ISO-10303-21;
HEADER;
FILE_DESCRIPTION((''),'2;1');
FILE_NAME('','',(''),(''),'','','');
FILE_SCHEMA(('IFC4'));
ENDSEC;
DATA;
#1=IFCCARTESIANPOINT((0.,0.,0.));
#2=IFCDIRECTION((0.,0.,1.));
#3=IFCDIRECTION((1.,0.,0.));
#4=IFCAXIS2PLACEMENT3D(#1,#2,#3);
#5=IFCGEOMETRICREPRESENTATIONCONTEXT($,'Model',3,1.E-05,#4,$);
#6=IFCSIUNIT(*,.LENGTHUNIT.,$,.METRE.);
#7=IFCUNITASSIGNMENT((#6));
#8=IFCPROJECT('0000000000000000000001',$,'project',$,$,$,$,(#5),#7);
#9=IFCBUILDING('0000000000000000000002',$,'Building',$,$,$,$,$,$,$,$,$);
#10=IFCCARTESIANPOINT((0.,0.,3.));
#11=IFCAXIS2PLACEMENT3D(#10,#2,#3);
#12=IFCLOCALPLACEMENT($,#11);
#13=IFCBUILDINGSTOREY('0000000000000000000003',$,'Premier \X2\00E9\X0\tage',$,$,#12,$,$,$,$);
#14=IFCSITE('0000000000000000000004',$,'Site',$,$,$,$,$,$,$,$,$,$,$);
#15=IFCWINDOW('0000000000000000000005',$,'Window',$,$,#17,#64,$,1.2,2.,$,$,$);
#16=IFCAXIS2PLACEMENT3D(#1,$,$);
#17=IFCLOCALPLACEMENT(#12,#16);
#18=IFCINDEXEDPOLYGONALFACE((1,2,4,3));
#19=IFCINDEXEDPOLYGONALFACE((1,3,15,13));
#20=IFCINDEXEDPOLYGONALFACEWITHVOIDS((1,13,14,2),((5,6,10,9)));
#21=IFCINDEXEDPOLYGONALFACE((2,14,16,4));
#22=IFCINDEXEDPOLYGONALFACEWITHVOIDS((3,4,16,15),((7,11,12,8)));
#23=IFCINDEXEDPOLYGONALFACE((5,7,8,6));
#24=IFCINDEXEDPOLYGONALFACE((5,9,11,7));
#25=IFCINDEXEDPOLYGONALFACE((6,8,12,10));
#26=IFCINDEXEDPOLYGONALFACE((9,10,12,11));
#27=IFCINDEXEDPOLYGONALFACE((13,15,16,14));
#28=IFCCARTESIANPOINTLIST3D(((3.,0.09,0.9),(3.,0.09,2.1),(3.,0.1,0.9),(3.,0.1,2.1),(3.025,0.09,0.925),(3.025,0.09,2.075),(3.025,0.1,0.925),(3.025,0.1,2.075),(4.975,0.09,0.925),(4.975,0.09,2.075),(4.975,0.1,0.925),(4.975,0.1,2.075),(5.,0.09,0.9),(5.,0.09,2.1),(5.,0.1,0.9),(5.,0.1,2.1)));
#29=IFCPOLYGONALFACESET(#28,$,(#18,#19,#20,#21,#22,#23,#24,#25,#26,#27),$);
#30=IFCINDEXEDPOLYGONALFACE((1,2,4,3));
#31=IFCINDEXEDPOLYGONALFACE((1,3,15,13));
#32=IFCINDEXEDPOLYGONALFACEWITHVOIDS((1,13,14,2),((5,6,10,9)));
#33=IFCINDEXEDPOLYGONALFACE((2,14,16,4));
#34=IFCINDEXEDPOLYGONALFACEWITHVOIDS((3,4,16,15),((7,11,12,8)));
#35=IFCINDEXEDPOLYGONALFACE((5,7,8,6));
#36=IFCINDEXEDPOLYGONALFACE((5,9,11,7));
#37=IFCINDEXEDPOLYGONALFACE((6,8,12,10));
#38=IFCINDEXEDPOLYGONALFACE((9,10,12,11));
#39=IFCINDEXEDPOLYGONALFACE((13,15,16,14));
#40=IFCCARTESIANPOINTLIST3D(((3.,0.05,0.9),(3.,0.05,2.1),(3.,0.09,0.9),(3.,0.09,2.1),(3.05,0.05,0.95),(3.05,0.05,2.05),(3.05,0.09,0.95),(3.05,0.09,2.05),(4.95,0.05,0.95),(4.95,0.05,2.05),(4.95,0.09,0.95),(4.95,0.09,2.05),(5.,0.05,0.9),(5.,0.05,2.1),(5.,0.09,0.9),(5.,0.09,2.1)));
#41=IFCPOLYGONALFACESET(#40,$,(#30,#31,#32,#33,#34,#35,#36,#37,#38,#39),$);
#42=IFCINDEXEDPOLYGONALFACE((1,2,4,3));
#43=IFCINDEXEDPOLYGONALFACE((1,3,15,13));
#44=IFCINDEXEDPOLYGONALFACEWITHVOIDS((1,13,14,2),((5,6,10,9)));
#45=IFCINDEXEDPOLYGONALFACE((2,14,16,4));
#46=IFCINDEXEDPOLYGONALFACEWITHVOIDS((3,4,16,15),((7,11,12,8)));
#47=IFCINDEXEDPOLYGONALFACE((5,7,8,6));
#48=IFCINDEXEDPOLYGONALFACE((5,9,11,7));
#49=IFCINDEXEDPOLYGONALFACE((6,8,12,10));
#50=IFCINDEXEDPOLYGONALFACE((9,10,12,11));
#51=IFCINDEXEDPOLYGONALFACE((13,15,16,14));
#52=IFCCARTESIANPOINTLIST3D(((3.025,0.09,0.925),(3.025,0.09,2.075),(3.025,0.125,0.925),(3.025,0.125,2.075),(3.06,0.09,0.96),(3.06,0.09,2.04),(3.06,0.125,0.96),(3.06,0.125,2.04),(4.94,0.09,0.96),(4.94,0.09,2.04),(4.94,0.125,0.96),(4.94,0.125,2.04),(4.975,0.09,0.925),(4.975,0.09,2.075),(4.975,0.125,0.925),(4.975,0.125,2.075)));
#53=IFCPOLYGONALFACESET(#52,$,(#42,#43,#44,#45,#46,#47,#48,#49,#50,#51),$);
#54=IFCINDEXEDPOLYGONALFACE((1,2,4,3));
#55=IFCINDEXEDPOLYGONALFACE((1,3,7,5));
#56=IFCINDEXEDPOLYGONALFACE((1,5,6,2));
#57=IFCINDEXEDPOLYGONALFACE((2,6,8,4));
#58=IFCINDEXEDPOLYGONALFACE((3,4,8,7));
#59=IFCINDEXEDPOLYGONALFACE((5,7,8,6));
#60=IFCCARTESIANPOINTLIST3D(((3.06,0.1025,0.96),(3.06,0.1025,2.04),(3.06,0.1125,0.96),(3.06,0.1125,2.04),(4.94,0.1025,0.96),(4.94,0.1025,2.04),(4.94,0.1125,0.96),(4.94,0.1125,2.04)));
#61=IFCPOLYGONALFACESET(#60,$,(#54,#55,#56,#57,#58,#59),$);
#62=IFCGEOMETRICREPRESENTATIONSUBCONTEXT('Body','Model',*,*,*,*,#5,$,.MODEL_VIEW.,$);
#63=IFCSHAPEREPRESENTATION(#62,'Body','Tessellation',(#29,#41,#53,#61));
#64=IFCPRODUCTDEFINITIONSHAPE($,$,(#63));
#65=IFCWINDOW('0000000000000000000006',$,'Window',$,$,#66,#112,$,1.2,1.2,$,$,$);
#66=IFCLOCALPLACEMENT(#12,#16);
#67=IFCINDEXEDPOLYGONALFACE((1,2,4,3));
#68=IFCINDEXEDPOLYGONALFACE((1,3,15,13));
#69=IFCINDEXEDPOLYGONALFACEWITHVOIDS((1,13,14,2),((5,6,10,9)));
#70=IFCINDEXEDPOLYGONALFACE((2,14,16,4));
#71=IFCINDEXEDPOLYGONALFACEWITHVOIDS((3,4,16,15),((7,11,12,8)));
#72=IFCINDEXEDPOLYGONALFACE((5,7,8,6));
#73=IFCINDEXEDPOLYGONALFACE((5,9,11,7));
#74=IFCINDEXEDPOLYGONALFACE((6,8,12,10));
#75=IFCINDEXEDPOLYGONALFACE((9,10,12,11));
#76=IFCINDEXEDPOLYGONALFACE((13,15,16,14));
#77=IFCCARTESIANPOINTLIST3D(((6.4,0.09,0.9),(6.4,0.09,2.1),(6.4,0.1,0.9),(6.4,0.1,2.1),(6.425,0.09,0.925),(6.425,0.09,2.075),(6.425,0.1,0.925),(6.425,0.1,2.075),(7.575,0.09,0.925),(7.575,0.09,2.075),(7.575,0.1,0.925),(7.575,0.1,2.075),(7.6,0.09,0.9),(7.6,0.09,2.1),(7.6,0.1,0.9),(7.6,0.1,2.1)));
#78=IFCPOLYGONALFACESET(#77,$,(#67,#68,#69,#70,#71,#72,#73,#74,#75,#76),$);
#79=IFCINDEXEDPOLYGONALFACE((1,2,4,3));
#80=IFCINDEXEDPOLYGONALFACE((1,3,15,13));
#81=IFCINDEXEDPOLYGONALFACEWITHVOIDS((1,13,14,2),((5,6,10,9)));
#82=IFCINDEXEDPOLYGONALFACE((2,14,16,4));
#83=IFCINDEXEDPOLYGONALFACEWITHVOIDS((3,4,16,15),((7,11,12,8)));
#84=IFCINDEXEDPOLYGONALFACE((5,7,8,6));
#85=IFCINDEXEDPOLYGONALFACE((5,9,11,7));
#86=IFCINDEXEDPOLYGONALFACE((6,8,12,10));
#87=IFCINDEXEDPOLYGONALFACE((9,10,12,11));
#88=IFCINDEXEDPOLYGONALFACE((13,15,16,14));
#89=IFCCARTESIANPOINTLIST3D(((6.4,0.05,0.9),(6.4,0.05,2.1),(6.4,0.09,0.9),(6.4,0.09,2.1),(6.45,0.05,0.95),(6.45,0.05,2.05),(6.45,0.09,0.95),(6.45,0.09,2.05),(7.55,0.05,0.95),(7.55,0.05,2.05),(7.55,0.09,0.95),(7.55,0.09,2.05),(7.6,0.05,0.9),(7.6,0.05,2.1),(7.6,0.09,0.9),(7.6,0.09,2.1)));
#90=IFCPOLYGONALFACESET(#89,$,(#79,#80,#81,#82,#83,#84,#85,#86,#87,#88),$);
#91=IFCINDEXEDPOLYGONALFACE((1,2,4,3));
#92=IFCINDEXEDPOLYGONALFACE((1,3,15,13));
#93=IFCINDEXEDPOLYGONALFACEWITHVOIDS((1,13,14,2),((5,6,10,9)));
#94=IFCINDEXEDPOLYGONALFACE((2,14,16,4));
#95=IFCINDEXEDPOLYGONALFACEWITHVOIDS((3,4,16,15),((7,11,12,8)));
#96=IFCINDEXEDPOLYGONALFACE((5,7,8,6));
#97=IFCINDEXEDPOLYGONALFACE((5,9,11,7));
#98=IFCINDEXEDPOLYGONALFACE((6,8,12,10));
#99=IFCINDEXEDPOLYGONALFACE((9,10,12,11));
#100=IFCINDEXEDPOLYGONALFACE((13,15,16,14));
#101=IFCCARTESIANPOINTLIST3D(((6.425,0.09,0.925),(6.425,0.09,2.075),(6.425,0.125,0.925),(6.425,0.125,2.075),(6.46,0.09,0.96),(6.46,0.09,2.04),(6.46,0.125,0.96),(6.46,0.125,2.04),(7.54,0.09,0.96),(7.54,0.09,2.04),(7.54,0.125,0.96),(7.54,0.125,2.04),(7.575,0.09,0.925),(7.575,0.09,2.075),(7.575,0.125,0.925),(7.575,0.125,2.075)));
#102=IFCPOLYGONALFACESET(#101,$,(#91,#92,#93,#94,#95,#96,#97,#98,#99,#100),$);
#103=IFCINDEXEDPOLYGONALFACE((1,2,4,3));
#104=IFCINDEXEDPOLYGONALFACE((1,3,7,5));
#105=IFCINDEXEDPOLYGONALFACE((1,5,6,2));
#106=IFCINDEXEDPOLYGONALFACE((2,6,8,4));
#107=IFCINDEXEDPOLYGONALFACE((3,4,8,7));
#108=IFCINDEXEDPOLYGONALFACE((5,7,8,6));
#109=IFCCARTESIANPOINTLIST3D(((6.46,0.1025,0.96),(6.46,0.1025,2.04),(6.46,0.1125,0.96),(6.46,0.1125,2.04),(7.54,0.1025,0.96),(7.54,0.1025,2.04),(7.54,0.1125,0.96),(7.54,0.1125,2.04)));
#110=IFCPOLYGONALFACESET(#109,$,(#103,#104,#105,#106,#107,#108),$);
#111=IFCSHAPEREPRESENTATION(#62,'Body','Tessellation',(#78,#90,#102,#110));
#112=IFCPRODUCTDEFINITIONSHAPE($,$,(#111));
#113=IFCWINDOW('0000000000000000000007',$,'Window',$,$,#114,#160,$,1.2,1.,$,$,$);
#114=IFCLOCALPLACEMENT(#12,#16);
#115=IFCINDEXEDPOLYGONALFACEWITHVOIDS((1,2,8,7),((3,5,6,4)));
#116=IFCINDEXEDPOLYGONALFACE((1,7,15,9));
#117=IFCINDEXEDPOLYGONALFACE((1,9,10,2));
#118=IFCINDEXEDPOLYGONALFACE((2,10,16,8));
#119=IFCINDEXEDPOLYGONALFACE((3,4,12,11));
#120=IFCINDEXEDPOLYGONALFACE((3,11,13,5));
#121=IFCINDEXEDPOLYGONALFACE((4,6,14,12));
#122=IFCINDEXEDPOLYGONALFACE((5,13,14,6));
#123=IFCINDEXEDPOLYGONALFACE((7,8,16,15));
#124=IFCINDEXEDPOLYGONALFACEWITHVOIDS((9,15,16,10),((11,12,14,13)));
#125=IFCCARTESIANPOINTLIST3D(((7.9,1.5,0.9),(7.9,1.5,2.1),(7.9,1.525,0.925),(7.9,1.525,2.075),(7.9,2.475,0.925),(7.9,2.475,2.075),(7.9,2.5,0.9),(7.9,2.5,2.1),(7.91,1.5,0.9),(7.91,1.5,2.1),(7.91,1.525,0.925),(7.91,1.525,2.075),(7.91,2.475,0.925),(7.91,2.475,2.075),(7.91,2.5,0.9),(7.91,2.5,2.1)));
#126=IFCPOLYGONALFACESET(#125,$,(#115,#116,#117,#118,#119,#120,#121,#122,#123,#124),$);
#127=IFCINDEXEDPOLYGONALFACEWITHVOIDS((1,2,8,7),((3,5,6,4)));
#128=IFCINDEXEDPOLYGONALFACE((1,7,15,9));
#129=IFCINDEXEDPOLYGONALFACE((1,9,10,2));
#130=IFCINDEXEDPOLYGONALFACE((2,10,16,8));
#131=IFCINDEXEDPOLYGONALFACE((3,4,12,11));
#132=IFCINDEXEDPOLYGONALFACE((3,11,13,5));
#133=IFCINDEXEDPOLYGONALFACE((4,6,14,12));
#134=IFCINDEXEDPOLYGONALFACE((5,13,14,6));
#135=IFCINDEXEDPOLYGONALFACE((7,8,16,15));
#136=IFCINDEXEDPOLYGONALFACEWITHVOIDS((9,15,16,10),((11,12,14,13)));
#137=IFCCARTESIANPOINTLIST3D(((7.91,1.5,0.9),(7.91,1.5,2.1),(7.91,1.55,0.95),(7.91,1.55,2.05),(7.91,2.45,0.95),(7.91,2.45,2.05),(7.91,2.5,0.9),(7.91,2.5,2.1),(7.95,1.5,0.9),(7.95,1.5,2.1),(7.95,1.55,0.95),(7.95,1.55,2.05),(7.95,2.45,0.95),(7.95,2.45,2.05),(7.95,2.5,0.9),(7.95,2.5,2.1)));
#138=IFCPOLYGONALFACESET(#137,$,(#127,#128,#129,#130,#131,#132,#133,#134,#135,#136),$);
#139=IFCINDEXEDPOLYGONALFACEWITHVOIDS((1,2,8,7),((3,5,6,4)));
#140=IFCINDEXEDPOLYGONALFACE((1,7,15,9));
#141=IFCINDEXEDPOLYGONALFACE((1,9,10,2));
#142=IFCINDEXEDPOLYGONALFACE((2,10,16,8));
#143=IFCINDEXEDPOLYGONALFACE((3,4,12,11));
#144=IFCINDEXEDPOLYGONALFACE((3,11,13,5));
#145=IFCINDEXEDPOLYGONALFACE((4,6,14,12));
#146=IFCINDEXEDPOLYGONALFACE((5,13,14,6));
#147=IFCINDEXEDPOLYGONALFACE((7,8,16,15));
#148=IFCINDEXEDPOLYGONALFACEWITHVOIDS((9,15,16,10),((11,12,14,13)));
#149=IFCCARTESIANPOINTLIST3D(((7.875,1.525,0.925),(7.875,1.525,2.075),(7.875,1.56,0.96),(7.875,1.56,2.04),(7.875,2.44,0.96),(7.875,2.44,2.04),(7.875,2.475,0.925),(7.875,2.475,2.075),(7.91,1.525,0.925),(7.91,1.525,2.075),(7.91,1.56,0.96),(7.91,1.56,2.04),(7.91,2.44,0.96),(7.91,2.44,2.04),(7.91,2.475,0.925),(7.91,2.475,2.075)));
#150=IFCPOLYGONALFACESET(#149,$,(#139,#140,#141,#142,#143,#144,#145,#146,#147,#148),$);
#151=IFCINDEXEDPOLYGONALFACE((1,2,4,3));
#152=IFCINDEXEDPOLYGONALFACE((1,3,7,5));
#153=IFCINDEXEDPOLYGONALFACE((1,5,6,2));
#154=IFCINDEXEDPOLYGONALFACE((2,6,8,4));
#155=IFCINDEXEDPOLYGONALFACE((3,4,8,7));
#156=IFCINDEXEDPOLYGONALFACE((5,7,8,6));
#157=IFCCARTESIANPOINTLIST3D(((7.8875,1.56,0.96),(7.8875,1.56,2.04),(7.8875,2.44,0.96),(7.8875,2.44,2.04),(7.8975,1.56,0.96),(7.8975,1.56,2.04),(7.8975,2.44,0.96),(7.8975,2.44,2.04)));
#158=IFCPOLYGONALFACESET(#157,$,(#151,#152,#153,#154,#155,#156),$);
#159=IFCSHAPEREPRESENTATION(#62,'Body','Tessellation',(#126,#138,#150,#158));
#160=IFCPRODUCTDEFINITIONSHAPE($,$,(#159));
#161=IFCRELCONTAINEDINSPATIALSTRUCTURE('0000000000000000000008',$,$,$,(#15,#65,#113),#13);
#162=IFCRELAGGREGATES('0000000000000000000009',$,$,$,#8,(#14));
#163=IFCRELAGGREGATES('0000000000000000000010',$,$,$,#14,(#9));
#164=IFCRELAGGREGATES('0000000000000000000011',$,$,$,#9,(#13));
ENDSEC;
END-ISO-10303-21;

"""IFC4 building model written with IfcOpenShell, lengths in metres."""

from ifc_helpers import new_model, si_unit, frame, origin_with_axes, place, context, subcontext, project, spatial, line, indexed_curve, outline, extrude, element, save


model = new_model("IFC4")

# Units and contexts
model_context = context("Model", 3, precision=1e-05, world=origin_with_axes())
body_context = subcontext(model_context, "Body", "Model", "MODEL_VIEW")
ifc_project = project(units=[si_unit("LENGTHUNIT", "METRE")], contexts=[model_context])

# Site, building, storey
site = spatial("IfcSite", under=ifc_project, Name="Site")
building = spatial("IfcBuilding", under=site, Name="Building")
storey_placement = place(None, frame((0.0, 0.0, 3.0), z_axis=(0.0, 0.0, 1.0), x_axis=(1.0, 0.0, 0.0)))
storey = spatial("IfcBuildingStorey", under=building, at=storey_placement, Name="Premier étage")

# Windows
window_1_placement = place(storey_placement, frame((3.0, 0.0, 0.9), z_axis=(0.0, 0.0, 1.0), x_axis=(1.0, 0.0, 0.0)))
element("IfcWindow", 1, at=window_1_placement, inside=storey, Name="Window", OverallHeight=1.2, OverallWidth=2.0, context=body_context, shape_type="SweptSolid", body=[
    extrude(outline(indexed_curve([(0.0, 0.0), (2.0, 0.0), (2.0, 1.2), (0.0, 1.2)], segments=[line(1, 2, 3, 4, 1)]), holes=[indexed_curve([(0.025, 0.025), (1.975, 0.025), (1.975, 1.175), (0.025, 1.175)], segments=[line(1, 2, 3, 4, 1)])]), frame((0.0, 0.09, 0.0), z_axis=(0.0, -1.0, 0.0), x_axis=(1.0, 0.0, 0.0)), (0.0, 0.0, -1.0), 0.01),
    extrude(outline(indexed_curve([(0.0, 0.0), (2.0, 0.0), (2.0, 1.2), (0.0, 1.2)], segments=[line(1, 2, 3, 4, 1)]), holes=[indexed_curve([(0.05, 0.05), (1.95, 0.05), (1.95, 1.15), (0.05, 1.15)], segments=[line(1, 2, 3, 4, 1)])]), frame((0.0, 0.05, 0.0), z_axis=(0.0, -1.0, 0.0), x_axis=(1.0, 0.0, 0.0)), (0.0, 0.0, -1.0), 0.04),
    extrude(outline(indexed_curve([(0.0, 0.0), (1.95, 0.0), (1.95, 1.15), (0.0, 1.15)], segments=[line(1, 2, 3, 4, 1)]), holes=[indexed_curve([(0.035, 0.035), (1.915, 0.035), (1.915, 1.115), (0.035, 1.115)], segments=[line(1, 2, 3, 4, 1)])]), frame((0.025, 0.09, 0.025), z_axis=(0.0, -1.0, 0.0), x_axis=(1.0, 0.0, 0.0)), (0.0, 0.0, -1.0), 0.035),
    extrude(outline(indexed_curve([(0.035, 0.035), (1.915, 0.035), (1.915, 1.115), (0.035, 1.115)], segments=[line(1, 2, 3, 4, 1)])), frame((0.025, 0.1025, 0.025), z_axis=(0.0, -1.0, 0.0), x_axis=(1.0, 0.0, 0.0)), (0.0, 0.0, -1.0), 0.01),
])
window_2_placement = place(storey_placement, frame((6.4, 0.0, 0.9), z_axis=(0.0, 0.0, 1.0), x_axis=(1.0, 0.0, 0.0)))
element("IfcWindow", 2, at=window_2_placement, inside=storey, Name="Window", OverallHeight=1.2, OverallWidth=1.2, context=body_context, shape_type="SweptSolid", body=[
    extrude(outline(indexed_curve([(0.0, 0.0), (1.2, 0.0), (1.2, 1.2), (0.0, 1.2)], segments=[line(1, 2, 3, 4, 1)]), holes=[indexed_curve([(0.025, 0.025), (1.175, 0.025), (1.175, 1.175), (0.025, 1.175)], segments=[line(1, 2, 3, 4, 1)])]), frame((0.0, 0.09, 0.0), z_axis=(0.0, -1.0, 0.0), x_axis=(1.0, 0.0, 0.0)), (0.0, 0.0, -1.0), 0.01),
    extrude(outline(indexed_curve([(0.0, 0.0), (1.2, 0.0), (1.2, 1.2), (0.0, 1.2)], segments=[line(1, 2, 3, 4, 1)]), holes=[indexed_curve([(0.05, 0.05), (1.15, 0.05), (1.15, 1.15), (0.05, 1.15)], segments=[line(1, 2, 3, 4, 1)])]), frame((0.0, 0.05, 0.0), z_axis=(0.0, -1.0, 0.0), x_axis=(1.0, 0.0, 0.0)), (0.0, 0.0, -1.0), 0.04),
    extrude(outline(indexed_curve([(0.0, 0.0), (1.15, 0.0), (1.15, 1.15), (0.0, 1.15)], segments=[line(1, 2, 3, 4, 1)]), holes=[indexed_curve([(0.035, 0.035), (1.115, 0.035), (1.115, 1.115), (0.035, 1.115)], segments=[line(1, 2, 3, 4, 1)])]), frame((0.025, 0.09, 0.025), z_axis=(0.0, -1.0, 0.0), x_axis=(1.0, 0.0, 0.0)), (0.0, 0.0, -1.0), 0.035),
    extrude(outline(indexed_curve([(0.035, 0.035), (1.115, 0.035), (1.115, 1.115), (0.035, 1.115)], segments=[line(1, 2, 3, 4, 1)])), frame((0.025, 0.1025, 0.025), z_axis=(0.0, -1.0, 0.0), x_axis=(1.0, 0.0, 0.0)), (0.0, 0.0, -1.0), 0.01),
])
window_3_placement = place(storey_placement, frame((8.0, 1.5, 0.9), z_axis=(0.0, 0.0, 1.0), x_axis=(0.0, 1.0, 0.0)))
element("IfcWindow", 3, at=window_3_placement, inside=storey, Name="Window", OverallHeight=1.2, OverallWidth=1.0, context=body_context, shape_type="SweptSolid", body=[
    extrude(outline(indexed_curve([(0.0, 0.0), (1.0, 0.0), (1.0, 1.2), (0.0, 1.2)], segments=[line(1, 2, 3, 4, 1)]), holes=[indexed_curve([(0.025, 0.025), (0.975, 0.025), (0.975, 1.175), (0.025, 1.175)], segments=[line(1, 2, 3, 4, 1)])]), frame((0.0, 0.09, 0.0), z_axis=(0.0, -1.0, 0.0), x_axis=(1.0, 0.0, 0.0)), (0.0, 0.0, -1.0), 0.01),
    extrude(outline(indexed_curve([(0.0, 0.0), (1.0, 0.0), (1.0, 1.2), (0.0, 1.2)], segments=[line(1, 2, 3, 4, 1)]), holes=[indexed_curve([(0.05, 0.05), (0.95, 0.05), (0.95, 1.15), (0.05, 1.15)], segments=[line(1, 2, 3, 4, 1)])]), frame((0.0, 0.05, 0.0), z_axis=(0.0, -1.0, 0.0), x_axis=(1.0, 0.0, 0.0)), (0.0, 0.0, -1.0), 0.04),
    extrude(outline(indexed_curve([(0.0, 0.0), (0.95, 0.0), (0.95, 1.15), (0.0, 1.15)], segments=[line(1, 2, 3, 4, 1)]), holes=[indexed_curve([(0.035, 0.035), (0.915, 0.035), (0.915, 1.115), (0.035, 1.115)], segments=[line(1, 2, 3, 4, 1)])]), frame((0.025, 0.09, 0.025), z_axis=(0.0, -1.0, 0.0), x_axis=(1.0, 0.0, 0.0)), (0.0, 0.0, -1.0), 0.035),
    extrude(outline(indexed_curve([(0.035, 0.035), (0.915, 0.035), (0.915, 1.115), (0.035, 1.115)], segments=[line(1, 2, 3, 4, 1)])), frame((0.025, 0.1025, 0.025), z_axis=(0.0, -1.0, 0.0), x_axis=(1.0, 0.0, 0.0)), (0.0, 0.0, -1.0), 0.01),
])

save(model, "model.ifc")
